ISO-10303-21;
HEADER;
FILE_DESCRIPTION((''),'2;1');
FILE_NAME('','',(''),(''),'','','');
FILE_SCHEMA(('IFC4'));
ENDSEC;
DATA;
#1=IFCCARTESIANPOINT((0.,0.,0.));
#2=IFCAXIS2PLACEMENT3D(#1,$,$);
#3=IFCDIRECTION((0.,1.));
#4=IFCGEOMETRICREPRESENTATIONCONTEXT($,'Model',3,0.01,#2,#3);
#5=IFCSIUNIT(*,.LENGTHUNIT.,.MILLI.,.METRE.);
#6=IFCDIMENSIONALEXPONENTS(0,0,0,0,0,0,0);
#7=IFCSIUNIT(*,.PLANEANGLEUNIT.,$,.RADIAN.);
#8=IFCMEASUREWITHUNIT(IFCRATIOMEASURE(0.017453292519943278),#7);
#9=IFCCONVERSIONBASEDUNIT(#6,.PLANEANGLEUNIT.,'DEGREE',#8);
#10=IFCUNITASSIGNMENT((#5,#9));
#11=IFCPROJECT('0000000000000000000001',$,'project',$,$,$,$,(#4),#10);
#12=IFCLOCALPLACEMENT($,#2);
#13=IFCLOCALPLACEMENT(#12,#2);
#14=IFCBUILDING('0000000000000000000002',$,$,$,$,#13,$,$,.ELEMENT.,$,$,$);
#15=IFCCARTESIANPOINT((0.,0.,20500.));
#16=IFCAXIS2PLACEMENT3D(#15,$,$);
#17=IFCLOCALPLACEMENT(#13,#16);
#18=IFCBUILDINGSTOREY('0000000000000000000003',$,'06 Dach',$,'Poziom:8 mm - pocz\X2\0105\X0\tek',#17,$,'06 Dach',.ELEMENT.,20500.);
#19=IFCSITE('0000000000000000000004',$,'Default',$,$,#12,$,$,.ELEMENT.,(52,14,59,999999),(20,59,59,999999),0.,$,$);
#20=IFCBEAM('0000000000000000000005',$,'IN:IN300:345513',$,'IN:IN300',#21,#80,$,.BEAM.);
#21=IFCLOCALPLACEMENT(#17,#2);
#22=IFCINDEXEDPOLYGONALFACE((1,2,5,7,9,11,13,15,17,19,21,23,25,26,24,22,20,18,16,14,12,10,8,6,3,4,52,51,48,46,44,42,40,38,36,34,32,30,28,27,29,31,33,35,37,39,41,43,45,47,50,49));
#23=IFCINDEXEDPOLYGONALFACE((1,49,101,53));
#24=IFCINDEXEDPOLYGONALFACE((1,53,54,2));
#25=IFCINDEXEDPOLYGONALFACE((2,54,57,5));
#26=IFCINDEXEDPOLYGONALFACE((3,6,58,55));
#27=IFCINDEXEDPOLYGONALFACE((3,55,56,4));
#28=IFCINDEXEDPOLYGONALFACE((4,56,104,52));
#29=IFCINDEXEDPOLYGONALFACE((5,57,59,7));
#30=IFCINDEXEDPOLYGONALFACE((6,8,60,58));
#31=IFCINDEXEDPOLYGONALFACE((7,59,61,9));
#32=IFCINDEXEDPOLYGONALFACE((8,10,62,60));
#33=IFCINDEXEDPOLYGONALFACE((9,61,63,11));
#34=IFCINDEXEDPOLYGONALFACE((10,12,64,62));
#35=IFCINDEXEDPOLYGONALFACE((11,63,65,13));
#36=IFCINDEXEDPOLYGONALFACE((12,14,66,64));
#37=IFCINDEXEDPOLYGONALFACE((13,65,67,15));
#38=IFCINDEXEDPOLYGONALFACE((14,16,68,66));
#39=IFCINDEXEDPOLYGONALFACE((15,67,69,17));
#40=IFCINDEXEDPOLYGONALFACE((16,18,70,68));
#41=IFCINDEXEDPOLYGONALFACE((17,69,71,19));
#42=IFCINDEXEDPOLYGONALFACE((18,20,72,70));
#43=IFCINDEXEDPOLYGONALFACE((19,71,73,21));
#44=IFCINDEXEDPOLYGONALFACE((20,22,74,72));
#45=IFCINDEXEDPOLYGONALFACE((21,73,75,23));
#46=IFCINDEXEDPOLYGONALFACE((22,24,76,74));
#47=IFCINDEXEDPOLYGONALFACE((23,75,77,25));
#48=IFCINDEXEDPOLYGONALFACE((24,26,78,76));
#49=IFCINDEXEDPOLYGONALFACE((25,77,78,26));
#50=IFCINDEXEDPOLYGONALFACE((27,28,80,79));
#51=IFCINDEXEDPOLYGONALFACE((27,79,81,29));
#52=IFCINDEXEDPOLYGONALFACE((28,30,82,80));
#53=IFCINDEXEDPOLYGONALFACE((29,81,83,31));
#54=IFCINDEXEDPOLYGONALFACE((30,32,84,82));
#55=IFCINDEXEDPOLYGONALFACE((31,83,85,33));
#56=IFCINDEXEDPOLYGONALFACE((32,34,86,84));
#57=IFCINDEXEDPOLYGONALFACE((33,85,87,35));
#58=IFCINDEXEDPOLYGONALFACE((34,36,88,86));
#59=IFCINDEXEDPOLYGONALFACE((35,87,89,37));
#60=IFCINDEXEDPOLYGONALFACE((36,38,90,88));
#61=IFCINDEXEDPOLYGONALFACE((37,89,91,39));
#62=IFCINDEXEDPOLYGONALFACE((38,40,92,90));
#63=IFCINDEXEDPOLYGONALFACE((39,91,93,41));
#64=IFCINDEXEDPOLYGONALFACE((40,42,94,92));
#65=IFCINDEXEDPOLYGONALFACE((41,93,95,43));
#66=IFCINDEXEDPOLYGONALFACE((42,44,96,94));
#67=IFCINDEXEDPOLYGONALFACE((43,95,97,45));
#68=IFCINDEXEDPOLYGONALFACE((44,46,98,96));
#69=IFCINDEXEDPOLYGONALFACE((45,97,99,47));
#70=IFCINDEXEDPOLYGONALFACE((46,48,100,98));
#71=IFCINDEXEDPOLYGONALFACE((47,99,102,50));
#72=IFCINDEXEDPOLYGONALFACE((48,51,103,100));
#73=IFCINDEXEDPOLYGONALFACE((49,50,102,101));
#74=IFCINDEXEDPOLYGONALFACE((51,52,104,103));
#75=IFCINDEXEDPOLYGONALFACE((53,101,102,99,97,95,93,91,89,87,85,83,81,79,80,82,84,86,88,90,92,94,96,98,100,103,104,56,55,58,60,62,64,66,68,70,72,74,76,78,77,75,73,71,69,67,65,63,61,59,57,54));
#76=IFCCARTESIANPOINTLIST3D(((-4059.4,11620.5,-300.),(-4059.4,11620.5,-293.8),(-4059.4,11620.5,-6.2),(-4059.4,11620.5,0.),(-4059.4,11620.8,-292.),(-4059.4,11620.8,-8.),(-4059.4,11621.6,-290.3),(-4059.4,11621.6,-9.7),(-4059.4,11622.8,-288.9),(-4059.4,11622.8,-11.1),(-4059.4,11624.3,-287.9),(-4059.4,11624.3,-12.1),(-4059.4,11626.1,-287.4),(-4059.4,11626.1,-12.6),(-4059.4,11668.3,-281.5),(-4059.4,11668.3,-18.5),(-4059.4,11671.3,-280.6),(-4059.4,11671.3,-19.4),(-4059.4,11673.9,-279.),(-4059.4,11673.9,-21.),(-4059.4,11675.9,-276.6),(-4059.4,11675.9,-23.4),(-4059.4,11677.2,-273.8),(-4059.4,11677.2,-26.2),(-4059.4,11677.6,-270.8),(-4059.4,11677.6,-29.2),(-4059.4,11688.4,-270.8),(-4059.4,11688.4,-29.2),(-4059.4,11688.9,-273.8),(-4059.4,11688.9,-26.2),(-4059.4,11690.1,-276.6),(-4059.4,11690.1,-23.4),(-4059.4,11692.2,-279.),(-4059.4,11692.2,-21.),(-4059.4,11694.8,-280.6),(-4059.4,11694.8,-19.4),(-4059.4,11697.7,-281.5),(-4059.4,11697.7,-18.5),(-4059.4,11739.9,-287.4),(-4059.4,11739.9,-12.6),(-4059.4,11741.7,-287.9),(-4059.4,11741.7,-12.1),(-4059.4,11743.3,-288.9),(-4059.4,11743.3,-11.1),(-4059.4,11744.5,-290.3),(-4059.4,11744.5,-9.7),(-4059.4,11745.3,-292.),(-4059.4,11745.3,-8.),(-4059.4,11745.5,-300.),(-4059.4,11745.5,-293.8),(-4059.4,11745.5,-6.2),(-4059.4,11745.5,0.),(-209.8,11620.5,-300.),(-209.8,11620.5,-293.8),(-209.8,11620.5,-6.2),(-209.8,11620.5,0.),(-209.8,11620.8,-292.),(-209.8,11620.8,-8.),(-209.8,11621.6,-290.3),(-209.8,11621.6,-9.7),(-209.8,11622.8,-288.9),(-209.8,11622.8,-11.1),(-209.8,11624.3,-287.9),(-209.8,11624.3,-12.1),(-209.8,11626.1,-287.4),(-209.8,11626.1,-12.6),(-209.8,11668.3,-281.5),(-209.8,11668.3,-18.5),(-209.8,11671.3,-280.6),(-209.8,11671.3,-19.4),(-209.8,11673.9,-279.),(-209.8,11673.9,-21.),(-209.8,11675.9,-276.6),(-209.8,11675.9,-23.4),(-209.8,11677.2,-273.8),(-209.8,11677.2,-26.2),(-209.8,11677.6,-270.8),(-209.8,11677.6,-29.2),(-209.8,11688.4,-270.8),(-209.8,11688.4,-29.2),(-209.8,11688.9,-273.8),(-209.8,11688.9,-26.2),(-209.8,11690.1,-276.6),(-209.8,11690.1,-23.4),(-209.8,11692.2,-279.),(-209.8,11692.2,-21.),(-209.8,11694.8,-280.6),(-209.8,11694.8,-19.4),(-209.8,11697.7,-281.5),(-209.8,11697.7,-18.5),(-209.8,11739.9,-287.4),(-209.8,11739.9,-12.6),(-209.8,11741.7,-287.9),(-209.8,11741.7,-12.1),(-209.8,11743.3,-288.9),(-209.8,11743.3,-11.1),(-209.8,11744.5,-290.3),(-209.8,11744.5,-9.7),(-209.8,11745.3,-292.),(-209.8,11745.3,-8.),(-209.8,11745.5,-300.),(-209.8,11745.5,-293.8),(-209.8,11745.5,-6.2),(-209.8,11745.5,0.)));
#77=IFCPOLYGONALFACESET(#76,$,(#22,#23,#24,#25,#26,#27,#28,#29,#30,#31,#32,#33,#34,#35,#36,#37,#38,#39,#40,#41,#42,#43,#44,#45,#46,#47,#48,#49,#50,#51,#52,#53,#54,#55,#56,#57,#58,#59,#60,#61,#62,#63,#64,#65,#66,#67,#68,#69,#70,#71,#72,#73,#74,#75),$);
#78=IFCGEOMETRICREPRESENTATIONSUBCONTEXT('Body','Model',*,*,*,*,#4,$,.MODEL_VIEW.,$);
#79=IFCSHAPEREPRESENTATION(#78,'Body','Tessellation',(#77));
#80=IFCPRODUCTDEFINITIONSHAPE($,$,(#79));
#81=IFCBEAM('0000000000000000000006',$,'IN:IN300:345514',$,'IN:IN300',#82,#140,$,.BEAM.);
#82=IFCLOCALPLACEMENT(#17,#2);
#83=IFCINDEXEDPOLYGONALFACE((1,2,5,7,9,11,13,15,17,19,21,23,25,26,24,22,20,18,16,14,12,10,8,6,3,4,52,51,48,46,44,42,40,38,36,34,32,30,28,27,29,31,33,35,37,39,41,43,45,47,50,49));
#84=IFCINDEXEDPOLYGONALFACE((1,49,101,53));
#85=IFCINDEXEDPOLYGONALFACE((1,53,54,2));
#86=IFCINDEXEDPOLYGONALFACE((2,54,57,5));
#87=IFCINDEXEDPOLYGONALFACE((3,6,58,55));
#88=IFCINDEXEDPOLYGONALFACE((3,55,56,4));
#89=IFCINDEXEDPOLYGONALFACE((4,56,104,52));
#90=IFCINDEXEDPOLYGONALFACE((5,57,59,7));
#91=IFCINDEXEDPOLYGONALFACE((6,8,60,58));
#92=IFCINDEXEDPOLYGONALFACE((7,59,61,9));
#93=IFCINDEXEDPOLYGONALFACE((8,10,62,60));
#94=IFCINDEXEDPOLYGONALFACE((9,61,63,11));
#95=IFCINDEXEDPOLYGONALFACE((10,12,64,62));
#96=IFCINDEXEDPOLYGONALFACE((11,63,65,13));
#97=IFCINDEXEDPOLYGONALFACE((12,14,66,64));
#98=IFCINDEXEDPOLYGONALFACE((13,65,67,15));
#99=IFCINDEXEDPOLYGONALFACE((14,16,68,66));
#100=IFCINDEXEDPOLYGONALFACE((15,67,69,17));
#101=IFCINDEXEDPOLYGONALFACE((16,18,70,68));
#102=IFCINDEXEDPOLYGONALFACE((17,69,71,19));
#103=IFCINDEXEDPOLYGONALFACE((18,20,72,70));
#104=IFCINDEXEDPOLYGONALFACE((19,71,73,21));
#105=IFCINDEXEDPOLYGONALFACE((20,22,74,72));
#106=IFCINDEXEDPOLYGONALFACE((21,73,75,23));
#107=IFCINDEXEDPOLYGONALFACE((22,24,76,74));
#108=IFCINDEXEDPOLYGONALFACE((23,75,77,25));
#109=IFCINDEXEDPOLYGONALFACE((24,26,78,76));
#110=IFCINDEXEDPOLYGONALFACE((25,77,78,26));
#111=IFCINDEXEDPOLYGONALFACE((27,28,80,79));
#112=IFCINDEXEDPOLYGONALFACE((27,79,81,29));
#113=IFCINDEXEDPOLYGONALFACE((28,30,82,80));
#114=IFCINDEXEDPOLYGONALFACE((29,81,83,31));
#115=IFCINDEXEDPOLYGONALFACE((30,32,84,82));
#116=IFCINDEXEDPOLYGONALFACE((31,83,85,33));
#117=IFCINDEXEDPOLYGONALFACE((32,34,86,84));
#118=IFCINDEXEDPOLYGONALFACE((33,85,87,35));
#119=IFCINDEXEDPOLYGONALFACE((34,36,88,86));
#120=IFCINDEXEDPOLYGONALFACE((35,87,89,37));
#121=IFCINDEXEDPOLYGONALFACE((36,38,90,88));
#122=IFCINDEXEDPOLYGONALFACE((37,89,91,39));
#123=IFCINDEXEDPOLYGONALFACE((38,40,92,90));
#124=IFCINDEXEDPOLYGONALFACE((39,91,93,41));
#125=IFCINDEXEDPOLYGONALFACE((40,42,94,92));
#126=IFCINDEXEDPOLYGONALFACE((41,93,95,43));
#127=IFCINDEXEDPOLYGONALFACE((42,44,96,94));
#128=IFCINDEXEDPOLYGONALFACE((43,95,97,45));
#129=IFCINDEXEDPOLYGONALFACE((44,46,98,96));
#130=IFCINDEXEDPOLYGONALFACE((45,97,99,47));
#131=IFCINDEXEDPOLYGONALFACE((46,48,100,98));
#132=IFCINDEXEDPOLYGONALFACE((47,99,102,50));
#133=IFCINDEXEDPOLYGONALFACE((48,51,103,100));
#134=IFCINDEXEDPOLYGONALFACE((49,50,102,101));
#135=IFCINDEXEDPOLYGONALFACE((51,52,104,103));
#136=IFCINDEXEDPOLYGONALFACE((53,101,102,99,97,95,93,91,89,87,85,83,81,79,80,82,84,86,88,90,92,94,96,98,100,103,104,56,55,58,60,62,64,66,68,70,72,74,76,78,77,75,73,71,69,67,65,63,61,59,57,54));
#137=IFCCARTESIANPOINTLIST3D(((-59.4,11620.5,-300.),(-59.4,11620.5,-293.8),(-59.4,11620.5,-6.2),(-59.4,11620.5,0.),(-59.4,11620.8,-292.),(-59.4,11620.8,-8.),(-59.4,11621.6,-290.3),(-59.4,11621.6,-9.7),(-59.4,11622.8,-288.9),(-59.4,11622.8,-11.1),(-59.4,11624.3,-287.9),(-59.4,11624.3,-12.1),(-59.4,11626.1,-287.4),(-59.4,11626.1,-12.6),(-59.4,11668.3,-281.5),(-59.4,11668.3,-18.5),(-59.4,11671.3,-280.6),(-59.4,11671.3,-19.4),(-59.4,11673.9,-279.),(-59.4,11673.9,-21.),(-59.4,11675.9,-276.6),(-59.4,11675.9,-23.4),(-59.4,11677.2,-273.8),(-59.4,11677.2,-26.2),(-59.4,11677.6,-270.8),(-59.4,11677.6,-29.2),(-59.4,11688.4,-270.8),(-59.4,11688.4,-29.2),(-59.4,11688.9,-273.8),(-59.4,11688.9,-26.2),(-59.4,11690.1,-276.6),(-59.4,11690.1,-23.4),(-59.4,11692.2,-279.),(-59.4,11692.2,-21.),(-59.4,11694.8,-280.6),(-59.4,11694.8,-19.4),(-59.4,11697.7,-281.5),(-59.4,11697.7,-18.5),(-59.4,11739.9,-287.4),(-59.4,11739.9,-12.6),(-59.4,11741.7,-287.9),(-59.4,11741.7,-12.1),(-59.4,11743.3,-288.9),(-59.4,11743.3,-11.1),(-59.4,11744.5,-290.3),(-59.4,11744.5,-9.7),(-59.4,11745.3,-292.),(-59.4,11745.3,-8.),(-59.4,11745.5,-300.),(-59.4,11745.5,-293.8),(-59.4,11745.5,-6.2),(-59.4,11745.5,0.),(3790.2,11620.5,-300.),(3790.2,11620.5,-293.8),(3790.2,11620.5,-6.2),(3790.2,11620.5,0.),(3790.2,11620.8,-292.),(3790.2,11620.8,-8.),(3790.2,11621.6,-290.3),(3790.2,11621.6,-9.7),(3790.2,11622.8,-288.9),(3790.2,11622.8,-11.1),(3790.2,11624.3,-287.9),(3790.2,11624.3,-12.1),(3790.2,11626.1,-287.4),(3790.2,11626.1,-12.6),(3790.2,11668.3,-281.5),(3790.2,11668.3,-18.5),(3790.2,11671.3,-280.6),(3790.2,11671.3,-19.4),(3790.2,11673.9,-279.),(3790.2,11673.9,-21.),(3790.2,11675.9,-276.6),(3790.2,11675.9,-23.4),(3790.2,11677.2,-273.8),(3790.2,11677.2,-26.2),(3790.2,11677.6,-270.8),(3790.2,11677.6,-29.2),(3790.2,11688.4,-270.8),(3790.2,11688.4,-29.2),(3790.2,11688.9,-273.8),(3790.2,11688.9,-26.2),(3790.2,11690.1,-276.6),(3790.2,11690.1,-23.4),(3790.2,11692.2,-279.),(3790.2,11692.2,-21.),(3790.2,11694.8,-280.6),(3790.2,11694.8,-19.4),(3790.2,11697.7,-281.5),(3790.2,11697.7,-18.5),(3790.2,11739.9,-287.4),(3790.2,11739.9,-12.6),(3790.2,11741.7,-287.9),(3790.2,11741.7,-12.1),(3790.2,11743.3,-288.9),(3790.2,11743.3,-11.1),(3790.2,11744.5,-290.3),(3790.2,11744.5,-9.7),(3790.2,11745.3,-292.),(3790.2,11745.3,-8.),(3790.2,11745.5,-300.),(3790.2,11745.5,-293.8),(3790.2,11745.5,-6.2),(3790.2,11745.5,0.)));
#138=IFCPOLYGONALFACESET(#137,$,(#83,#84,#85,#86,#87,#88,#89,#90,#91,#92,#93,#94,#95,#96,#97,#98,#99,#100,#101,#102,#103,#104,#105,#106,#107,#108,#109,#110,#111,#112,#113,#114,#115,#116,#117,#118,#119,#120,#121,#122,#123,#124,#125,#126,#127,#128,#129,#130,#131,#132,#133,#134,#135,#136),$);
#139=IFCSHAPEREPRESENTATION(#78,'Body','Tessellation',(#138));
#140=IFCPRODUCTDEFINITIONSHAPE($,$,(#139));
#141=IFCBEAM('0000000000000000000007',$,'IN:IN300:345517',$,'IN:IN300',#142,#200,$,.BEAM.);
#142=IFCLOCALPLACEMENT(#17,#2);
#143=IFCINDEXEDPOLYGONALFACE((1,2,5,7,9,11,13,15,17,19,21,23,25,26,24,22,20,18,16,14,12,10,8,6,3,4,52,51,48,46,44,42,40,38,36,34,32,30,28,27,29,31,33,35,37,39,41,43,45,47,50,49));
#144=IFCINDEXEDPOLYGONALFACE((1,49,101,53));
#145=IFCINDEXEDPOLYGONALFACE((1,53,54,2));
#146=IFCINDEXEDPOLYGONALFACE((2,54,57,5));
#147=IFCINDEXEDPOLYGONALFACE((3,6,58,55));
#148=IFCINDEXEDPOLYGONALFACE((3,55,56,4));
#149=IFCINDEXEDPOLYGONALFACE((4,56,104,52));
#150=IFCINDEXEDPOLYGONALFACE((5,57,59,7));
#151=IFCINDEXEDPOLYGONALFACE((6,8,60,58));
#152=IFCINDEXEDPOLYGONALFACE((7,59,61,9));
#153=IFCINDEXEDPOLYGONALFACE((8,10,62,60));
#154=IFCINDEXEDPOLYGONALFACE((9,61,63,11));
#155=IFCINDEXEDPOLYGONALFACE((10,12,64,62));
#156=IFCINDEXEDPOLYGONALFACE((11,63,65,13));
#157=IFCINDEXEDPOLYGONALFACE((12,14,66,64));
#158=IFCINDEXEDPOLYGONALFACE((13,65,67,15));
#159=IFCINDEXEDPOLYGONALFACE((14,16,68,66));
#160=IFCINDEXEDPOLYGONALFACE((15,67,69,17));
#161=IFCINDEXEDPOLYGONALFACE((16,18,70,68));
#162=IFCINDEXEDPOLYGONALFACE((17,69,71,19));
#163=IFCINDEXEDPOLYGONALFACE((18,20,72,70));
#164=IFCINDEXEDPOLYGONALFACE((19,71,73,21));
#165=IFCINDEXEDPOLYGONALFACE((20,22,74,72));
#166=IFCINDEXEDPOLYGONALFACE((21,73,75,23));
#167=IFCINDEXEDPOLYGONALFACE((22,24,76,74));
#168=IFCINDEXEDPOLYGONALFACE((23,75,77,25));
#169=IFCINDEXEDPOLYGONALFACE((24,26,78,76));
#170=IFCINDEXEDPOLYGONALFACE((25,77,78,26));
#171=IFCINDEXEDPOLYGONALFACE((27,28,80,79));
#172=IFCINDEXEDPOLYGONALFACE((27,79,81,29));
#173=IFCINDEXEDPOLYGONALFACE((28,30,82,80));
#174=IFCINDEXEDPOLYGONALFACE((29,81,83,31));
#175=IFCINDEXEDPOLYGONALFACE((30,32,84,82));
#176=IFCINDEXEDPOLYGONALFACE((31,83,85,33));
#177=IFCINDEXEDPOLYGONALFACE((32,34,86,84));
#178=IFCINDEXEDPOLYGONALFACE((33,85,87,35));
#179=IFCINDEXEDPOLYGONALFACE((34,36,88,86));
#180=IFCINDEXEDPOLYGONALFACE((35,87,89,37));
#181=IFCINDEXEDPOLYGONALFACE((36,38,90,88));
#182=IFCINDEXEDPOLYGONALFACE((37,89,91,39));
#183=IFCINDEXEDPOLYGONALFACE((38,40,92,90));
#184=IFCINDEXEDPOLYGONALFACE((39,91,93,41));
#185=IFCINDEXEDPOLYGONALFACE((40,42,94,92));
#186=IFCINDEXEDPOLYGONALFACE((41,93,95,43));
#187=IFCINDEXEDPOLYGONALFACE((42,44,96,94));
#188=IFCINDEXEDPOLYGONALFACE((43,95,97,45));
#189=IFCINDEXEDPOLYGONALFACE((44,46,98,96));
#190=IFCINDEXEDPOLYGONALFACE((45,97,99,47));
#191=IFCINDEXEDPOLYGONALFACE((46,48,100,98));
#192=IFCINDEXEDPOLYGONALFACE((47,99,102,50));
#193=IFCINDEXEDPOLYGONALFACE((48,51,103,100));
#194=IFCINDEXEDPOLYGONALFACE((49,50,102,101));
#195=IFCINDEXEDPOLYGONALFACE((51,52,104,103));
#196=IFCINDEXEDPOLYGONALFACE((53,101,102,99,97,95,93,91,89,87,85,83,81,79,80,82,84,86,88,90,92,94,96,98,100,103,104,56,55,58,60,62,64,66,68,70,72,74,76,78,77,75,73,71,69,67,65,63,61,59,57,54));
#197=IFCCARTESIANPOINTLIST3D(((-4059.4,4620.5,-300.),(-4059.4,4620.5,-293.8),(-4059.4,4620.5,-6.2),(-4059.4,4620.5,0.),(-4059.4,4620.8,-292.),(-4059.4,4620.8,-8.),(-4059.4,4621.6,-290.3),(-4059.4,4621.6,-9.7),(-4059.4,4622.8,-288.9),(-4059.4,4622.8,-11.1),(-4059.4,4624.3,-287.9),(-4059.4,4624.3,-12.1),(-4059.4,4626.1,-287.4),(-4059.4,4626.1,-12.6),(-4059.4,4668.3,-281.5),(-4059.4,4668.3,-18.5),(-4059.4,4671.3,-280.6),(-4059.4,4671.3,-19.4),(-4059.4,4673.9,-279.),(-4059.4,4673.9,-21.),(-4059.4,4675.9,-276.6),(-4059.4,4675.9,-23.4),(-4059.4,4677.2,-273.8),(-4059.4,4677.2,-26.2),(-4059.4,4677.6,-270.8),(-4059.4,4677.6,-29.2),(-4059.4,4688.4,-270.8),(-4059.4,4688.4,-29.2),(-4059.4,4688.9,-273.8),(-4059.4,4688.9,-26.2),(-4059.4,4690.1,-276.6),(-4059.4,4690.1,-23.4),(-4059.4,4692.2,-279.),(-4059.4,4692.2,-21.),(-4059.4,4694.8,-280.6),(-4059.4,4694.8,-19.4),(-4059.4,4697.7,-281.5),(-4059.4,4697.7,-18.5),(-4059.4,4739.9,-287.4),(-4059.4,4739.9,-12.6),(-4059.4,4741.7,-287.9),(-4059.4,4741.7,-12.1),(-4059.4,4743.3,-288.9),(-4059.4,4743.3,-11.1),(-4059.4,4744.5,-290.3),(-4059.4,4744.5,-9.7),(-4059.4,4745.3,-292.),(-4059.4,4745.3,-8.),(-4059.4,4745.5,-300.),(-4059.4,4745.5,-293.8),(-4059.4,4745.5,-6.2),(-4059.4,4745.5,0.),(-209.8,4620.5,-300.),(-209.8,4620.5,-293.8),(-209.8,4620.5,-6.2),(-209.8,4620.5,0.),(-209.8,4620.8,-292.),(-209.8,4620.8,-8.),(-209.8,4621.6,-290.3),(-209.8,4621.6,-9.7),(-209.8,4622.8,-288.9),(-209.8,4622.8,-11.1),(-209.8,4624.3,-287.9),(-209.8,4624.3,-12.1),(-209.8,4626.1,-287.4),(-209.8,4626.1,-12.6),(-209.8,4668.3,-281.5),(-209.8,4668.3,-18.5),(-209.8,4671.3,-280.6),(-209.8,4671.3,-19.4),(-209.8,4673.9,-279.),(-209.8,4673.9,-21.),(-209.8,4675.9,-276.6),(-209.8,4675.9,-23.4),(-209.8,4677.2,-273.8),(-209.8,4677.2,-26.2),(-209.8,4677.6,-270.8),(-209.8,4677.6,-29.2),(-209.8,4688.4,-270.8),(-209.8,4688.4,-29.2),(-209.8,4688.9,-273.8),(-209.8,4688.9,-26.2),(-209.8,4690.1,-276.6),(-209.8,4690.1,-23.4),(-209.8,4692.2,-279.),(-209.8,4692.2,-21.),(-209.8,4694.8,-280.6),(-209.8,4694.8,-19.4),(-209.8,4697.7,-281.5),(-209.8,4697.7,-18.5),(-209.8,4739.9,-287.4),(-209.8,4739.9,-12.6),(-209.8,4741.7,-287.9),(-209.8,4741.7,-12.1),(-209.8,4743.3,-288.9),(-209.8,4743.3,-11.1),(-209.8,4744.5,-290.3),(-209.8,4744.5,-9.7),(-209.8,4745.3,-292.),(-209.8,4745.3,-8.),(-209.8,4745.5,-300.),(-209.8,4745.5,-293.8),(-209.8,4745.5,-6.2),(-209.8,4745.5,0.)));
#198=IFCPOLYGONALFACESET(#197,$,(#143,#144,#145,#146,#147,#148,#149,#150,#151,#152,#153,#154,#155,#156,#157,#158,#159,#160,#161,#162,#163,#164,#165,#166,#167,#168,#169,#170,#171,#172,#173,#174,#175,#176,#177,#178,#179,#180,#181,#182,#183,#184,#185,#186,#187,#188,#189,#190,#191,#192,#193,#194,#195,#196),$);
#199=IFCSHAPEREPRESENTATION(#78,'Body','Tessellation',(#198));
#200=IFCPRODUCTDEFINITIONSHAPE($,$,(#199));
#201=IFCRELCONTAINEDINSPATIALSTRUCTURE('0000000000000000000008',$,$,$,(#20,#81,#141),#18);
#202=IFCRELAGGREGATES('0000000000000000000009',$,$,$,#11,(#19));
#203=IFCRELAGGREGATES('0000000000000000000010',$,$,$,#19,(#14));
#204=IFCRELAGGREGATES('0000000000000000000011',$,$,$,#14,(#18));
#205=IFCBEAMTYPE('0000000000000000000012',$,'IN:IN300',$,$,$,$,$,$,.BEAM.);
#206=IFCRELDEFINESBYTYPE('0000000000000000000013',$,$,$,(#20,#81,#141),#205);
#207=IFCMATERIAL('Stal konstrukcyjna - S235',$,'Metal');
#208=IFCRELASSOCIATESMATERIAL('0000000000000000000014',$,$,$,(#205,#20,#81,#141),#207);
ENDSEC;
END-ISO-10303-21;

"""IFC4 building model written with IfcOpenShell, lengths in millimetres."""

from ifc_helpers import new_model, entity, si_unit, converted_unit, direction, frame, origin, place, context, subcontext, project, spatial, line, arc, indexed_curve, outline, extrude, source, transform, mapped, material, type_object, type_shapes, element, save


model = new_model("IFC4")

# Units and contexts
model_context = context("Model", 3, precision=0.01, world=origin(), true_north=direction((0.0, 1.0)))
body_context = subcontext(model_context, "Body", "Model", "MODEL_VIEW")
ifc_project = project(units=[si_unit("LENGTHUNIT", "METRE", prefix="MILLI"), converted_unit("PLANEANGLEUNIT", "DEGREE", entity("IfcRatioMeasure", 0.017453292519943278), si_unit("PLANEANGLEUNIT", "RADIAN"), dimensions=[0, 0, 0, 0, 0, 0, 0])], contexts=[model_context])

# Site, building, storey
site_placement = place(None, origin())
site = spatial("IfcSite", under=ifc_project, at=site_placement, Name="Default", CompositionType="ELEMENT", RefLatitude=(52, 14, 59, 999999), RefLongitude=(20, 59, 59, 999999), RefElevation=0.0)
building_placement = place(site_placement, origin())
building = spatial("IfcBuilding", under=site, at=building_placement, CompositionType="ELEMENT")
storey_placement = place(building_placement, frame((0.0, 0.0, 20500.0)))
storey = spatial("IfcBuildingStorey", under=building, at=storey_placement, Name="06 Dach", ObjectType="Poziom:8 mm - początek", LongName="06 Dach", CompositionType="ELEMENT", Elevation=20500.0)

# Beams
ifc_material = material(Name="Stal konstrukcyjna - S235", Category="Metal")
beam_type_1 = type_object("IfcBeamType", Name="IN:IN300", PredefinedType="BEAM", material=ifc_material)
shared_shape_1 = source(origin(), body_context, "Body", "SweptSolid", [
    extrude(outline(indexed_curve([(143.8, -62.5), (150.0, -62.5), (150.0, 62.5), (143.8, 62.5), (139.6, 60.9), (137.4, 56.9), (131.5, 14.7), (127.9, 8.1), (120.8, 5.4), (-120.8, 5.4), (-127.9, 8.1), (-131.5, 14.7), (-137.4, 56.9), (-139.6, 60.9), (-143.8, 62.5), (-150.0, 62.5), (-150.0, -62.5), (-143.8, -62.5), (-139.6, -60.9), (-137.4, -56.9), (-131.5, -14.7), (-127.9, -8.1), (-120.8, -5.4), (120.8, -5.4), (127.9, -8.1), (131.5, -14.7), (137.4, -56.9), (139.6, -60.9)], segments=[line(1, 2, 3, 4), arc(4, 5, 6), line(6, 7), arc(7, 8, 9), line(9, 10), arc(10, 11, 12), line(12, 13), arc(13, 14, 15), line(15, 16, 17, 18), arc(18, 19, 20), line(20, 21), arc(21, 22, 23), line(23, 24), arc(24, 25, 26), line(26, 27), arc(27, 28, 1)], self_intersect=False)), frame((-1924.8, 0.0, 0.0), z_axis=(1.0, 0.0, 0.0), x_axis=(0.0, 0.0, -1.0)), (0.0, 0.0, 1.0), 3849.6),
])
type_shapes(beam_type_1, [shared_shape_1])
for number, where, name in (
    (1, (-2134.6, 11683.0, -150.0), "IN:IN300:345513"),
    (2, (1865.4, 11683.0, -150.0), "IN:IN300:345514"),
    (3, (-2134.6, 4683.0, -150.0), "IN:IN300:345517"),
):
    element("IfcBeam", number, at=place(storey_placement, frame(where)), inside=storey, type_object=beam_type_1, material=ifc_material, Name=name, ObjectType="IN:IN300", PredefinedType="BEAM", context=body_context, shape_type="MappedRepresentation", body=[
        mapped(shared_shape_1, transform((0.0, 0.0, 0.0), scale=1.0)),
    ])

save(model, "model.ifc")
